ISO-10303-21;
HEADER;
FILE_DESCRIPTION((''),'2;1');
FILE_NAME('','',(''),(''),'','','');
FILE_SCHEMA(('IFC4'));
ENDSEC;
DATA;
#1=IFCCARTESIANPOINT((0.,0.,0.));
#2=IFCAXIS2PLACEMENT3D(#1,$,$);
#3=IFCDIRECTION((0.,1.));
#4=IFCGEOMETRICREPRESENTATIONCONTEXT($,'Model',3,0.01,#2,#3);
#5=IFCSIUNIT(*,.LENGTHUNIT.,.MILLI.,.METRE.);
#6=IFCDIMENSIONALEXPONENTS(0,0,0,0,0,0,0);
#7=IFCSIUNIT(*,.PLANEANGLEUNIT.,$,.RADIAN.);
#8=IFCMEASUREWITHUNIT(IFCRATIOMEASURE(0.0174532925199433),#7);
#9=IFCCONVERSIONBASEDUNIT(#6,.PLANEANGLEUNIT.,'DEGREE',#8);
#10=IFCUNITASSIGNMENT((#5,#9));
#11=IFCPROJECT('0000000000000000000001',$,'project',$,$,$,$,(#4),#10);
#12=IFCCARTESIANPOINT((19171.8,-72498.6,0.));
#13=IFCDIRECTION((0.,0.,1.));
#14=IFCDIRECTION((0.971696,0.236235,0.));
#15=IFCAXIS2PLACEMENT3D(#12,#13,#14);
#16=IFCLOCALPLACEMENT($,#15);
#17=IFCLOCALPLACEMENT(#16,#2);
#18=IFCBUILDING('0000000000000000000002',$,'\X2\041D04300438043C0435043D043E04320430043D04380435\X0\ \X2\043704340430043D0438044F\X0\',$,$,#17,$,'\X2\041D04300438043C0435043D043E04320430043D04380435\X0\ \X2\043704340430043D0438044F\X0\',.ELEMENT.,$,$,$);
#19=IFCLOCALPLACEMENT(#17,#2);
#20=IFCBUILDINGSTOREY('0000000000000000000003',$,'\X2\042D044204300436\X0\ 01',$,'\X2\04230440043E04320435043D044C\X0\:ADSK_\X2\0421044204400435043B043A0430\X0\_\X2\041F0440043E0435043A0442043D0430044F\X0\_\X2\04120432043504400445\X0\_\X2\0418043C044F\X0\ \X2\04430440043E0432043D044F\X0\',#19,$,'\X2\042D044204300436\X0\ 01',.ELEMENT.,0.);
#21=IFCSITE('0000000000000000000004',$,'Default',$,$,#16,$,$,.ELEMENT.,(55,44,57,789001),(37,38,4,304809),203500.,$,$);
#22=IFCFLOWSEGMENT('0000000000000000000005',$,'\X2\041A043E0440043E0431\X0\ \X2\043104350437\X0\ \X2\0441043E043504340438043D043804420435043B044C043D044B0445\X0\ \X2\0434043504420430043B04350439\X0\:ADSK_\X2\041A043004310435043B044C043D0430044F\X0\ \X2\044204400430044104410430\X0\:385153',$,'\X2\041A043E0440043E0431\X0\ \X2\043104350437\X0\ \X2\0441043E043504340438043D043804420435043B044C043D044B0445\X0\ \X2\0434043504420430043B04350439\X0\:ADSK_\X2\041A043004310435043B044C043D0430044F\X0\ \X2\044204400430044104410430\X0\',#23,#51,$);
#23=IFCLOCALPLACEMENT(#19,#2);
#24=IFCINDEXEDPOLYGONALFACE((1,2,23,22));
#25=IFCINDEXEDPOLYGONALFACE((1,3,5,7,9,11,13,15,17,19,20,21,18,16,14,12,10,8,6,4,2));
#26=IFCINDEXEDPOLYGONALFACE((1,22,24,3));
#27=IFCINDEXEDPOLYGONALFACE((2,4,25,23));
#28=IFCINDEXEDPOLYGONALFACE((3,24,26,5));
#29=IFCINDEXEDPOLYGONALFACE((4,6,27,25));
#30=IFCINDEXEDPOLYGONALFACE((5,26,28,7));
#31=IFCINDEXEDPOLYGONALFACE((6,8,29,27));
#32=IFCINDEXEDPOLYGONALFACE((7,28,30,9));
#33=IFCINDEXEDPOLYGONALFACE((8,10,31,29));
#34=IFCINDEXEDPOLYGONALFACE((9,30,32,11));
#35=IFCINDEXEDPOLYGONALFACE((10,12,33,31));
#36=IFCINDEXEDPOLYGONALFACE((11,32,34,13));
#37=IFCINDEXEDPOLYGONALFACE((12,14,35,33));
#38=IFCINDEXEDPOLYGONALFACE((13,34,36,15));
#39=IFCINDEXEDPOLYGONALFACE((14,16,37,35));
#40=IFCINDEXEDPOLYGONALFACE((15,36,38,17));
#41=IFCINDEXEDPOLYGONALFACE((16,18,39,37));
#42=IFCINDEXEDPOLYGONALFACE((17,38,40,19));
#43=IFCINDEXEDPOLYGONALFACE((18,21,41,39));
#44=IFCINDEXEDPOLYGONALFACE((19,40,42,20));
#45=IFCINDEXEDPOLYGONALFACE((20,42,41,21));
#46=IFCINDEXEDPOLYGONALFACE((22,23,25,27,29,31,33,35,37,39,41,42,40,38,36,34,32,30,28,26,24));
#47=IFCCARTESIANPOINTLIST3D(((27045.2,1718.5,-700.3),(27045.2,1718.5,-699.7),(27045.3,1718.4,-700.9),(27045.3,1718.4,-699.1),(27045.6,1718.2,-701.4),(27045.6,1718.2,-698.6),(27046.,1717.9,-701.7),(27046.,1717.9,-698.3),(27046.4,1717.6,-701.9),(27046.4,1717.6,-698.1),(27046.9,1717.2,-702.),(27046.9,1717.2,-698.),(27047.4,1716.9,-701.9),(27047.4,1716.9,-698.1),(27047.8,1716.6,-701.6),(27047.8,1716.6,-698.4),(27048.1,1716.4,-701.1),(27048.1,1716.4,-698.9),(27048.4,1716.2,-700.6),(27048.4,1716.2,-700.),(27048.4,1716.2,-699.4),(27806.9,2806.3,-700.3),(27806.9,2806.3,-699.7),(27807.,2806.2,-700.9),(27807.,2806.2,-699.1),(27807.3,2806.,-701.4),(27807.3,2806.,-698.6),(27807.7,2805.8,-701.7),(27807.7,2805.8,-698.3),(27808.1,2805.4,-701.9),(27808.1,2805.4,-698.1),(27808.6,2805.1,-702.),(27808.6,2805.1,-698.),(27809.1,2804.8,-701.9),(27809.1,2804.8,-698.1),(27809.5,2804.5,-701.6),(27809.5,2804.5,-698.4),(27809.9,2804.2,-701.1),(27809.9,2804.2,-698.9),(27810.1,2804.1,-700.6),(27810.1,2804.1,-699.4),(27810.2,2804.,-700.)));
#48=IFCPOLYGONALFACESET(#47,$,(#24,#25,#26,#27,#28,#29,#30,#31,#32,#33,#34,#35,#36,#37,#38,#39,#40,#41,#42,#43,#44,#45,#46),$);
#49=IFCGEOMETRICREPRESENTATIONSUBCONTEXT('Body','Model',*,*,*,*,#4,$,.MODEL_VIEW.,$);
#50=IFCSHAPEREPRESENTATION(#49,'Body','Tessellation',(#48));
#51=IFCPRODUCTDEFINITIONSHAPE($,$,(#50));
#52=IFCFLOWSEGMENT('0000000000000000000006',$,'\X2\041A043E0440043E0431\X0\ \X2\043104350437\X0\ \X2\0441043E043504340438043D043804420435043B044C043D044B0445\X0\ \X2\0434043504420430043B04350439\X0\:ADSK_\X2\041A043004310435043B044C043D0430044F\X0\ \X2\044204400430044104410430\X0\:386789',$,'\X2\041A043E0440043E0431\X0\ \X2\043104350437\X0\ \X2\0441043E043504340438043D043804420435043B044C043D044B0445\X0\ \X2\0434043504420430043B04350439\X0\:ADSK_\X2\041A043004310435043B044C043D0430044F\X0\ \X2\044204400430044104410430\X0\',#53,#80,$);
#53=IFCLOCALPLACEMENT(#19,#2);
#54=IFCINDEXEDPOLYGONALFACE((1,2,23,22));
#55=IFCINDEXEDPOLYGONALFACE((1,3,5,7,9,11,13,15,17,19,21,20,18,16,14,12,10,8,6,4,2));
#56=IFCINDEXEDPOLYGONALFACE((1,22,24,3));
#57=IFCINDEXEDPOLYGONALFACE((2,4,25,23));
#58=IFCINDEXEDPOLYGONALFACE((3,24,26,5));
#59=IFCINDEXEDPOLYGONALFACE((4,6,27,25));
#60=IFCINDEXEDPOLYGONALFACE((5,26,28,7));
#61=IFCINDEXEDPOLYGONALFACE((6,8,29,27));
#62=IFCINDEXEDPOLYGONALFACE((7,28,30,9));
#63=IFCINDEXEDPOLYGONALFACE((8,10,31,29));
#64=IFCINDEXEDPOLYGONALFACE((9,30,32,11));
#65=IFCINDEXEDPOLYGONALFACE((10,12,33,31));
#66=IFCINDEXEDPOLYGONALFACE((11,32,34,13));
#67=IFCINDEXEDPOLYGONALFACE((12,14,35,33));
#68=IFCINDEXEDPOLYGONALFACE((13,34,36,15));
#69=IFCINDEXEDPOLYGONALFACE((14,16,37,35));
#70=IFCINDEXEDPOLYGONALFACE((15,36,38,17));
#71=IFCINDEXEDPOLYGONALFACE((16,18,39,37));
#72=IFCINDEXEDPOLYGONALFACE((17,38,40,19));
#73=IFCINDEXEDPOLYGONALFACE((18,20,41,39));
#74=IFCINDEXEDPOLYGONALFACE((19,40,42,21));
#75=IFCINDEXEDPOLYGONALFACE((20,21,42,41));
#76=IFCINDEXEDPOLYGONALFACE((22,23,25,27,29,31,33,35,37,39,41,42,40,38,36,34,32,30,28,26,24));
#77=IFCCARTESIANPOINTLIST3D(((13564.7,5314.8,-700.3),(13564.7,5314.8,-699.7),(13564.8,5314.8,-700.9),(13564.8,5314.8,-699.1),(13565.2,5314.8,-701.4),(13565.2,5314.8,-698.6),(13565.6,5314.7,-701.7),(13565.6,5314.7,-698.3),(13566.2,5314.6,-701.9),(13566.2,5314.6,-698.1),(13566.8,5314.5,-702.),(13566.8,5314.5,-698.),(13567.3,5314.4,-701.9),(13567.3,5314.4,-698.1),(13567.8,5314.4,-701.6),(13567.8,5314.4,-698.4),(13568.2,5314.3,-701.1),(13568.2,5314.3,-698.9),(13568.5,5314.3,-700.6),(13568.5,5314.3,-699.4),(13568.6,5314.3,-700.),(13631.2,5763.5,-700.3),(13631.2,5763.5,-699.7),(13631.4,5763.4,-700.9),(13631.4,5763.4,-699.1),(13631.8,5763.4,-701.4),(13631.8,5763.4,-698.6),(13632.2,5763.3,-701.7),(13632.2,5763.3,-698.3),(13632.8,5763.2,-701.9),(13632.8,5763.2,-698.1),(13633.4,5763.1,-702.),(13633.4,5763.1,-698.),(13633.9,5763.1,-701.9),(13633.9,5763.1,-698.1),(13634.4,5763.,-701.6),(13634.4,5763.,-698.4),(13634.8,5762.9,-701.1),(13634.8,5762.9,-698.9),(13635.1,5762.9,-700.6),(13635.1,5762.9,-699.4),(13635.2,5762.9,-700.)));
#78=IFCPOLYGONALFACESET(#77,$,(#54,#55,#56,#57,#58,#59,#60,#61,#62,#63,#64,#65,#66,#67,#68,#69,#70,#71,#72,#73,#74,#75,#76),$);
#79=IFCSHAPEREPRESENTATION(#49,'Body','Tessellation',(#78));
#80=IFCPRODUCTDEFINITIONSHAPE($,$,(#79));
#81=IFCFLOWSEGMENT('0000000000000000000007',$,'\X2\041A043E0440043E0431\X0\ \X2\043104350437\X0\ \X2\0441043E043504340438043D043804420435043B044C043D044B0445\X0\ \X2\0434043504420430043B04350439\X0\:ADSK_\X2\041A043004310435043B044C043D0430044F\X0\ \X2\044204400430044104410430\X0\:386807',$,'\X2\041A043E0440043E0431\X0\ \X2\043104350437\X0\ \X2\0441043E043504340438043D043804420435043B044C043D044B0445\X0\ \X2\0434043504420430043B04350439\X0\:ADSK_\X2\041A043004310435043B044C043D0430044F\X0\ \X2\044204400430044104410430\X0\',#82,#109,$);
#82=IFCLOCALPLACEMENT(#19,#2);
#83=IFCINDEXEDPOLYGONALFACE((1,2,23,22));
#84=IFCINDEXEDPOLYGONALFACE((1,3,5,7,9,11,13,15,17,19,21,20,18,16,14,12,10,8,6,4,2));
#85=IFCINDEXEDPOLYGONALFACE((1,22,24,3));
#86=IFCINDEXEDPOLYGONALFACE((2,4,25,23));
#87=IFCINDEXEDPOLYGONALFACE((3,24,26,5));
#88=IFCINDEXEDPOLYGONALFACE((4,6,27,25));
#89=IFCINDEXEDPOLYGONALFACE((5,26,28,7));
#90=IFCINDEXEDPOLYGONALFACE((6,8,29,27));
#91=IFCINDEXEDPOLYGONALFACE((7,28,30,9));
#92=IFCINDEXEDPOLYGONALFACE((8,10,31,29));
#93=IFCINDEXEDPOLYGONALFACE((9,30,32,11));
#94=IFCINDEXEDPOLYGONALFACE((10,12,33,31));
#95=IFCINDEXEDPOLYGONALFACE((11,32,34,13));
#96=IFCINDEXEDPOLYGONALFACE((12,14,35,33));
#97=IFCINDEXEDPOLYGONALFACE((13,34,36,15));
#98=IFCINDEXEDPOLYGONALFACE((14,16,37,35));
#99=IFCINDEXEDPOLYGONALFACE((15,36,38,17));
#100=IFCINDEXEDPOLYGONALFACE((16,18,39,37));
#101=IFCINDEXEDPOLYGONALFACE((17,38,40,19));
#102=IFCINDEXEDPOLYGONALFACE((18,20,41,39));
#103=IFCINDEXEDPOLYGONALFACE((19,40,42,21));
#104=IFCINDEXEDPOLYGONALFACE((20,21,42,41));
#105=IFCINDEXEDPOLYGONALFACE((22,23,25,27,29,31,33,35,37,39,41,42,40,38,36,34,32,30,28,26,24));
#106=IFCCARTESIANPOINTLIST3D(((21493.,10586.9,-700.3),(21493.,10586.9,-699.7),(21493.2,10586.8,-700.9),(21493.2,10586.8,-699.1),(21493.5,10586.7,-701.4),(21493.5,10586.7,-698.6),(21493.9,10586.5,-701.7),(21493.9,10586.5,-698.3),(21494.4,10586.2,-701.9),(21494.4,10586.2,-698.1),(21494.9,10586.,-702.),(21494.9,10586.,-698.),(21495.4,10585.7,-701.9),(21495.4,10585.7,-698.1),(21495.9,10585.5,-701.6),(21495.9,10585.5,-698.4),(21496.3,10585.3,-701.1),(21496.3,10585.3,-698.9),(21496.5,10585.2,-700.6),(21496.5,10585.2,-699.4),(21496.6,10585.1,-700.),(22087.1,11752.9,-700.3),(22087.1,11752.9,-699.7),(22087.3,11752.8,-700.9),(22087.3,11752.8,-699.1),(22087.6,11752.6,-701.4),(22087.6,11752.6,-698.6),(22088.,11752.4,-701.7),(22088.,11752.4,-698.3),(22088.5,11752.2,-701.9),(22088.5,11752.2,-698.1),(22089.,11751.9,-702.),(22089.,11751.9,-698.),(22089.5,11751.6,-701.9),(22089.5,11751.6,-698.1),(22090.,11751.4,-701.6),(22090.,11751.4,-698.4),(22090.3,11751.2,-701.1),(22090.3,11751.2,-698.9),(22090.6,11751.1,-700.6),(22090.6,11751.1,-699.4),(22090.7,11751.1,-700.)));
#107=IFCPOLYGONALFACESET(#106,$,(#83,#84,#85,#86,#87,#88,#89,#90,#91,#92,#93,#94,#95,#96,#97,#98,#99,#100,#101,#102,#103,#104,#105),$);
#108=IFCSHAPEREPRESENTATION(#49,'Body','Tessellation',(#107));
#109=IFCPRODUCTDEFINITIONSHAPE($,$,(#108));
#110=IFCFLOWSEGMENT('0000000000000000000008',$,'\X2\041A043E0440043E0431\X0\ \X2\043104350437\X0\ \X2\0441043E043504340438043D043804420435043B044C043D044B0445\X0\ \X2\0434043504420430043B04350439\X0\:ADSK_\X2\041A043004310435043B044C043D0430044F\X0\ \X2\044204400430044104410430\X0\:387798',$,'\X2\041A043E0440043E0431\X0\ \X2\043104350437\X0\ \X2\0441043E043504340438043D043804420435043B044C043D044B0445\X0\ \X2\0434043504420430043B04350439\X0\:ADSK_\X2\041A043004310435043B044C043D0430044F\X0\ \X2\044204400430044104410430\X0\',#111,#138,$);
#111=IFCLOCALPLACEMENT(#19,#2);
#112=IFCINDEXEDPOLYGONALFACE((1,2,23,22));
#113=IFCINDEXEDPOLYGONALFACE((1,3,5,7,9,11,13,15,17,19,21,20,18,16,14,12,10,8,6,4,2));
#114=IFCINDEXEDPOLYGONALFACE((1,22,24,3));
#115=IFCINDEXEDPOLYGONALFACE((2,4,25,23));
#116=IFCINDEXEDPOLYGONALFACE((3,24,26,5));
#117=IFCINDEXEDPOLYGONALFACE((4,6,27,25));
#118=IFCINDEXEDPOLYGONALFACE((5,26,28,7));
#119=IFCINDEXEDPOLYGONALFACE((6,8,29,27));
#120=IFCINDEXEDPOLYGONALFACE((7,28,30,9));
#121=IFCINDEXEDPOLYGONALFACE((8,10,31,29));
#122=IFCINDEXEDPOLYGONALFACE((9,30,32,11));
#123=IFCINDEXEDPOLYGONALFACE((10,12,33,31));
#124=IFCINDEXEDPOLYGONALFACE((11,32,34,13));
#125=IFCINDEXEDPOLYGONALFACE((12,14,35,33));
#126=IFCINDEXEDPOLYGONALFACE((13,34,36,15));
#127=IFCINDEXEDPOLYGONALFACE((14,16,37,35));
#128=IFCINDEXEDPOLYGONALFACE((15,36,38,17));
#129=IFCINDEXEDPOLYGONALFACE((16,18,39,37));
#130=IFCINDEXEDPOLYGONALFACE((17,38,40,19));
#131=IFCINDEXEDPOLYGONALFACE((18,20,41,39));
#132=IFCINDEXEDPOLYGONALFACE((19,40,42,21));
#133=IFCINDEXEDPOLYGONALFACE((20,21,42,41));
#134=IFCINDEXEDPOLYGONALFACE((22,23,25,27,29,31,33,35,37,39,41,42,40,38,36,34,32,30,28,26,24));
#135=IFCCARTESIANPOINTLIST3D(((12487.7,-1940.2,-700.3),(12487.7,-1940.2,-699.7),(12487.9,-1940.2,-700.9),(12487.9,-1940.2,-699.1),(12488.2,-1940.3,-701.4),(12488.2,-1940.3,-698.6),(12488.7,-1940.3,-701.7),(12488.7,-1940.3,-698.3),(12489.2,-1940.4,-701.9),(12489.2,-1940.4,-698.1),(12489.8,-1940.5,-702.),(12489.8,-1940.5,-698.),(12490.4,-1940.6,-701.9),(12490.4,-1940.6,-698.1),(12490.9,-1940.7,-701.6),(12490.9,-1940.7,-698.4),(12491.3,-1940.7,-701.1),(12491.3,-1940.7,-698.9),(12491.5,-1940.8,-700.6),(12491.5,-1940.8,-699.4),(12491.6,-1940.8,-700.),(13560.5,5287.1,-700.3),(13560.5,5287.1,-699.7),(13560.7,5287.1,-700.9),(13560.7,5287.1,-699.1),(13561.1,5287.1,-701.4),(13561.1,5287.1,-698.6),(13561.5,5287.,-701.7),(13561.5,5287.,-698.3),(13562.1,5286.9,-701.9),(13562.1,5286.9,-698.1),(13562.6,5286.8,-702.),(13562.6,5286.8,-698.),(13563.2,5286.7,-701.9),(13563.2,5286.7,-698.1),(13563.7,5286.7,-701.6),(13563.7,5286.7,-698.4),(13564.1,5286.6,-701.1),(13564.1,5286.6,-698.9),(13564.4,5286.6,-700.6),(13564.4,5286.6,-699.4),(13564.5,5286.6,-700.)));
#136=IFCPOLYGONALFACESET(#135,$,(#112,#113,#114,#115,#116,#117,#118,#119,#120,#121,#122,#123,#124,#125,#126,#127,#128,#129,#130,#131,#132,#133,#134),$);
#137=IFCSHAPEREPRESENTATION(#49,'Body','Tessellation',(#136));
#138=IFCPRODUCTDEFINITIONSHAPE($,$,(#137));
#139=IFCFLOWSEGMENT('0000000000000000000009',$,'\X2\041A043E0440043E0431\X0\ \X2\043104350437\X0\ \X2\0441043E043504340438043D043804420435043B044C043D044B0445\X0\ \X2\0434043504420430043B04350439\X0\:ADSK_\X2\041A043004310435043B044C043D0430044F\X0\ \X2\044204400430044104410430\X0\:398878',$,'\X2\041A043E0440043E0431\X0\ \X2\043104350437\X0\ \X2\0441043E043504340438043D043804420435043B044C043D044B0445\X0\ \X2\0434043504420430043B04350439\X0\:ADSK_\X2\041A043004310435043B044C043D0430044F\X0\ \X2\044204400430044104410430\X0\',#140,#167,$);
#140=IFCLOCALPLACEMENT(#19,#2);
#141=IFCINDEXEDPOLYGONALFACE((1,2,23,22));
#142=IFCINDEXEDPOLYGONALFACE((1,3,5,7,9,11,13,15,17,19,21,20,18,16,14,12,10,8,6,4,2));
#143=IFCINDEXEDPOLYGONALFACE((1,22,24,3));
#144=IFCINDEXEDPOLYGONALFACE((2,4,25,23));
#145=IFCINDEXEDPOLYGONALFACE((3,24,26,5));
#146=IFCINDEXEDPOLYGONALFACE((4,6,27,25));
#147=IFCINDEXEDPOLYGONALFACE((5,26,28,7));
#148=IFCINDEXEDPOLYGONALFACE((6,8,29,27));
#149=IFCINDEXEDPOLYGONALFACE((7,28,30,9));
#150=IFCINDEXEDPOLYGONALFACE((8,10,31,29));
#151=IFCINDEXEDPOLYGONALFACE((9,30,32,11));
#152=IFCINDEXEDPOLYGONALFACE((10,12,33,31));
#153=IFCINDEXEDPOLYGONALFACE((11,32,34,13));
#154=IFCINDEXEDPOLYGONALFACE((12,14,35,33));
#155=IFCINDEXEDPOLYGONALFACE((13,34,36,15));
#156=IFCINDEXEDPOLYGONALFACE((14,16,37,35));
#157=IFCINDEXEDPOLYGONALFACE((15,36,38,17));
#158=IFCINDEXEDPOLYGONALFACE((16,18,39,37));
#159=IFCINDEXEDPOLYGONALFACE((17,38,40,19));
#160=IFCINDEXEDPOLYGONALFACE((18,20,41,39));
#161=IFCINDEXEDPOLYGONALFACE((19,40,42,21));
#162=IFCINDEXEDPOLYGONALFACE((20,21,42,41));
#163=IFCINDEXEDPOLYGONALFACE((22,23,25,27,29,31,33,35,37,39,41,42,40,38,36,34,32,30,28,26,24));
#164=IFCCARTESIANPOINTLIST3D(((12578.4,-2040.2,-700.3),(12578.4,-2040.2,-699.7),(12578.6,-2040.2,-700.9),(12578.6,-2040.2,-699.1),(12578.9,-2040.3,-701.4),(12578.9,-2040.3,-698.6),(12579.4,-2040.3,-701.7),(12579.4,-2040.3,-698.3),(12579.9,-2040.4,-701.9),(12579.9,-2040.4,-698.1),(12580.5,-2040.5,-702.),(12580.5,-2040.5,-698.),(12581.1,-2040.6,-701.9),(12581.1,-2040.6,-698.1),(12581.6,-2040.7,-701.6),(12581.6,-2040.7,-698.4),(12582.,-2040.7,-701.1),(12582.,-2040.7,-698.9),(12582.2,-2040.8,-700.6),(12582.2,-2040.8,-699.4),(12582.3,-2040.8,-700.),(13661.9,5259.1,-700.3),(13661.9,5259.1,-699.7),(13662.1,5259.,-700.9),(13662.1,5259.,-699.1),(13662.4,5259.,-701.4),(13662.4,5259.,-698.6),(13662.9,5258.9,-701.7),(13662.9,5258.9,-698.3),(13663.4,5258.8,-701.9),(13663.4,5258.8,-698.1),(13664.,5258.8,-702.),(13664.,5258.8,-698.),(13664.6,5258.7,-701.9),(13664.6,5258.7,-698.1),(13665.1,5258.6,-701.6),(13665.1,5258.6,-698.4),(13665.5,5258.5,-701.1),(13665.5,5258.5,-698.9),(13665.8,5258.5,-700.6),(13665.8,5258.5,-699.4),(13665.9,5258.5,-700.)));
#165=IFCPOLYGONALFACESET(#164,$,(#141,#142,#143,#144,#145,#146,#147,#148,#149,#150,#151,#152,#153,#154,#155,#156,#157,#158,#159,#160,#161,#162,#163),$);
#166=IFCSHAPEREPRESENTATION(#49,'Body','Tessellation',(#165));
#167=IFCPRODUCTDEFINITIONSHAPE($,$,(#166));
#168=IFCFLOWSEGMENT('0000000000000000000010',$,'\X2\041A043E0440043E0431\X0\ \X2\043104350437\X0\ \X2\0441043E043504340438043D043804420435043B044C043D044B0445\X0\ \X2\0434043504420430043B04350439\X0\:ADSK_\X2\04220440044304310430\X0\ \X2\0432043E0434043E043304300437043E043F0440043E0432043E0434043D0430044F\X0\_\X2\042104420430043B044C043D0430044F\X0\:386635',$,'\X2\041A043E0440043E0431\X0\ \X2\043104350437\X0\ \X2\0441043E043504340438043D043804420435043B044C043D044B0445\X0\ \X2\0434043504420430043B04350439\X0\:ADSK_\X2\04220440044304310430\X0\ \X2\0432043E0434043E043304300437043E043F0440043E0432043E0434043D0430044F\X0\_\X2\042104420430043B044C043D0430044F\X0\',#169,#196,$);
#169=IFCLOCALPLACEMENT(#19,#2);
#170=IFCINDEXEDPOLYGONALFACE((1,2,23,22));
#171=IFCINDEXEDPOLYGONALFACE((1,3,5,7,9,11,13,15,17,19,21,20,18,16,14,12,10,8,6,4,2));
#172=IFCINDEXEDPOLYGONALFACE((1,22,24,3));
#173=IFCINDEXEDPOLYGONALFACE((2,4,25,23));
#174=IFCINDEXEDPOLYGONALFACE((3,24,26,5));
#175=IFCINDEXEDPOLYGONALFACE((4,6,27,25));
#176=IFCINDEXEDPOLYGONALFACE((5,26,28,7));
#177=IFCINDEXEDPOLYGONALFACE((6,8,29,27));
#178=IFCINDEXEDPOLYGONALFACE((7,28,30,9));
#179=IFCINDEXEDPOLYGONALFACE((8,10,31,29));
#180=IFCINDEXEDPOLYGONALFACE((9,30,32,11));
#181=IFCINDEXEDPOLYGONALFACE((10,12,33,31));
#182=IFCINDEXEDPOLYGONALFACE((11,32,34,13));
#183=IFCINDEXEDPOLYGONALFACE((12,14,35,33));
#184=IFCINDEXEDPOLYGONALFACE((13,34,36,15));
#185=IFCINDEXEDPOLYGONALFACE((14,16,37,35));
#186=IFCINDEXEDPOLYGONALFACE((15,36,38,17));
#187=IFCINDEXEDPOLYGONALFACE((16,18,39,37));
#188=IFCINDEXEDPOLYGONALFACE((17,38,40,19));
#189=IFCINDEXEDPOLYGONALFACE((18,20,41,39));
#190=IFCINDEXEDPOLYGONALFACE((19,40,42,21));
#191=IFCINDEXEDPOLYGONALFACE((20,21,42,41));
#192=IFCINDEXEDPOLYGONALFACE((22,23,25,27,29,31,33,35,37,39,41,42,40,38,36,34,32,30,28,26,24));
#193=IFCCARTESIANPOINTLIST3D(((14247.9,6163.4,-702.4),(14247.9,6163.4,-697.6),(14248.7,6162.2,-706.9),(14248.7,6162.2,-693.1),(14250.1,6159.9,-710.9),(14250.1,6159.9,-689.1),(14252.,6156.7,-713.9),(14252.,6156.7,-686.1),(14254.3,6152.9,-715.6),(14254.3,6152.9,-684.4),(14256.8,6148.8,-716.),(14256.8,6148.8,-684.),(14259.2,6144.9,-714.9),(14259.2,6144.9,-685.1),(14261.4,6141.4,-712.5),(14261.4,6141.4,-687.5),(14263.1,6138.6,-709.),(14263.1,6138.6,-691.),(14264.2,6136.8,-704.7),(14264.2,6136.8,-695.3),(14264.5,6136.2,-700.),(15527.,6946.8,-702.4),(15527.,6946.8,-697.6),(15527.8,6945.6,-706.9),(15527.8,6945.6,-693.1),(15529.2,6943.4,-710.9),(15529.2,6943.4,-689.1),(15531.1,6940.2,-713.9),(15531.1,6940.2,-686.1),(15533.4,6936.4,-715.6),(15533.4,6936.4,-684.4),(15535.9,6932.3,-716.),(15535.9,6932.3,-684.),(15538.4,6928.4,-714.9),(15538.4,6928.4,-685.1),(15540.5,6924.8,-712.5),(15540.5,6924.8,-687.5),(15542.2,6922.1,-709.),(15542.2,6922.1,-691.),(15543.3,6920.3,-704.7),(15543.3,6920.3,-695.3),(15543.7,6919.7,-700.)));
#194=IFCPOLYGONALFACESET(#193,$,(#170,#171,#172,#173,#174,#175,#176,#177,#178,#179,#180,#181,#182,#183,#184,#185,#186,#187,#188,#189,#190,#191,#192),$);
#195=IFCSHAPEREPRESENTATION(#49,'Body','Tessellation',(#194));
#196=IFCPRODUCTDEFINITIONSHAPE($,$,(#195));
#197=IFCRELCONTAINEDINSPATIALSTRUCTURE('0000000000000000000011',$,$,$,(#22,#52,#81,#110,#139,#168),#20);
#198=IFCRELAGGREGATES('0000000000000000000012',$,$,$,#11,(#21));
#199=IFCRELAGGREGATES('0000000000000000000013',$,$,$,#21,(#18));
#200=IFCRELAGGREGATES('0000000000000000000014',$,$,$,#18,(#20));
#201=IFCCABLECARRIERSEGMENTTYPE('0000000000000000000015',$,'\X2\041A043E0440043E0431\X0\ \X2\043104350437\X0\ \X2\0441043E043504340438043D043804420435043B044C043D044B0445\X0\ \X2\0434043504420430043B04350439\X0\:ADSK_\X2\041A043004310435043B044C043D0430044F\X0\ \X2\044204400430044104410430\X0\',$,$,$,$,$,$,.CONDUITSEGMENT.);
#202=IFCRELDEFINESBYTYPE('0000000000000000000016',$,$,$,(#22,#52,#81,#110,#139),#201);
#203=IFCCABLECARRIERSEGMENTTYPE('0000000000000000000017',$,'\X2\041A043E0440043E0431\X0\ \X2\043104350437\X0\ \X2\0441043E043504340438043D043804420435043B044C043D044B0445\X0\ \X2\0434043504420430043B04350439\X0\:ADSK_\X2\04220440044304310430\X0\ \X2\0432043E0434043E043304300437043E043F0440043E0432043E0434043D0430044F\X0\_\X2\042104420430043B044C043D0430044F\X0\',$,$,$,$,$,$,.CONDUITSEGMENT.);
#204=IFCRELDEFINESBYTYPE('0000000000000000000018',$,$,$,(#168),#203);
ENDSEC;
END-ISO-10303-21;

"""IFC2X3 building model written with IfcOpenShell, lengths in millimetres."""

from ifc_helpers import new_model, entity, si_unit, converted_unit, direction, frame, origin, origin_2d_with_axis, place, context, subcontext, project, spatial, circle, extrude, type_object, element, save


model = new_model("IFC2X3")

# Units and contexts
model_context = context("Model", 3, precision=0.01, world=origin(), true_north=direction((0.0, 1.0)))
body_context = subcontext(model_context, "Body", "Model", "MODEL_VIEW")
ifc_project = project(units=[si_unit("LENGTHUNIT", "METRE", prefix="MILLI"), converted_unit("PLANEANGLEUNIT", "DEGREE", entity("IfcRatioMeasure", 0.0174532925199433), si_unit("PLANEANGLEUNIT", "RADIAN"), dimensions=[0, 0, 0, 0, 0, 0, 0])], contexts=[model_context])

# Site, building, storey
site_placement = place(None, frame((19171.8, -72498.6, 0.0), z_axis=(0.0, 0.0, 1.0), x_axis=(0.971696, 0.236235, 0.0)))
site = spatial("IfcSite", under=ifc_project, at=site_placement, Name="Default", CompositionType="ELEMENT", RefLatitude=(55, 44, 57, 789001), RefLongitude=(37, 38, 4, 304809), RefElevation=203500.0)
building_placement = place(site_placement, origin())
building = spatial("IfcBuilding", under=site, at=building_placement, Name="Наименование здания", LongName="Наименование здания", CompositionType="ELEMENT")
storey_placement = place(building_placement, origin())
storey = spatial("IfcBuildingStorey", under=building, at=storey_placement, Name="Этаж 01", ObjectType="Уровень:ADSK_Стрелка_Проектная_Вверх_Имя уровня", LongName="Этаж 01", CompositionType="ELEMENT", Elevation=0.0)

# Flow segments
cable_carrier_segment_type_1 = type_object("IfcCableCarrierSegmentType", Name="Короб без соединительных деталей:ADSK_Кабельная трасса", PredefinedType="CONDUITSEGMENT")
flow_segment_1_placement = place(storey_placement, frame((27043.6, 1714.6, -703.6)))
element("IfcFlowSegment", 1, at=flow_segment_1_placement, inside=storey, type_object=cable_carrier_segment_type_1, Name="Короб без соединительных деталей:ADSK_Кабельная трасса:385153", ObjectType="Короб без соединительных деталей:ADSK_Кабельная трасса", context=body_context, shape_type="SweptSolid", body=[
    extrude(circle(Radius=2.0, at=origin_2d_with_axis()), frame((3.2, 2.7, 3.6), z_axis=(0.573576, 0.819152, 0.0), x_axis=(0.819152, -0.573576, 0.0)), (0.0, 0.0, 1.0), 1328.0),
])
flow_segment_2_placement = place(storey_placement, frame((13563.0, 5312.7, -703.6)))
element("IfcFlowSegment", 2, at=flow_segment_2_placement, inside=storey, type_object=cable_carrier_segment_type_1, Name="Короб без соединительных деталей:ADSK_Кабельная трасса:386789", ObjectType="Короб без соединительных деталей:ADSK_Кабельная трасса", context=body_context, shape_type="SweptSolid", body=[
    extrude(circle(Radius=2.0, at=origin_2d_with_axis()), frame((3.6, 1.9, 3.6), z_axis=(0.146835, 0.989161, 0.0), x_axis=(0.989161, -0.146835, 0.0)), (0.0, 0.0, 1.0), 453.5),
])
flow_segment_3_placement = place(storey_placement, frame((21491.4, 10583.5, -703.6)))
element("IfcFlowSegment", 3, at=flow_segment_3_placement, inside=storey, type_object=cable_carrier_segment_type_1, Name="Короб без соединительных деталей:ADSK_Кабельная трасса:386807", ObjectType="Короб без соединительных деталей:ADSK_Кабельная трасса", context=body_context, shape_type="SweptSolid", body=[
    extrude(circle(Radius=2.0, at=origin_2d_with_axis()), frame((3.4, 2.5, 3.6), z_axis=(0.45399, 0.891007, 0.0), x_axis=(0.891007, -0.45399, 0.0)), (0.0, 0.0, 1.0), 1308.6),
])
flow_segment_4_placement = place(storey_placement, frame((12486.1, -1942.4, -703.6)))
element("IfcFlowSegment", 4, at=flow_segment_4_placement, inside=storey, type_object=cable_carrier_segment_type_1, Name="Короб без соединительных деталей:ADSK_Кабельная трасса:387798", ObjectType="Короб без соединительных деталей:ADSK_Кабельная трасса", context=body_context, shape_type="SweptSolid", body=[
    extrude(circle(Radius=2.0, at=origin_2d_with_axis()), frame((3.6, 1.9, 3.6), z_axis=(0.146835, 0.989161, 0.0), x_axis=(0.989161, -0.146835, 0.0)), (0.0, 0.0, 1.0), 7306.5),
])
flow_segment_5_placement = place(storey_placement, frame((12576.8, -2042.4, -703.6)))
element("IfcFlowSegment", 5, at=flow_segment_5_placement, inside=storey, type_object=cable_carrier_segment_type_1, Name="Короб без соединительных деталей:ADSK_Кабельная трасса:398878", ObjectType="Короб без соединительных деталей:ADSK_Кабельная трасса", context=body_context, shape_type="SweptSolid", body=[
    extrude(circle(Radius=2.0, at=origin_2d_with_axis()), frame((3.6, 1.9, 3.6), z_axis=(0.146835, 0.989161, 0.0), x_axis=(0.989161, -0.146835, 0.0)), (0.0, 0.0, 1.0), 7379.2),
])
cable_carrier_segment_type_2 = type_object("IfcCableCarrierSegmentType", Name="Короб без соединительных деталей:ADSK_Труба водогазопроводная_Стальная", PredefinedType="CONDUITSEGMENT")
flow_segment_6_placement = place(storey_placement, frame((14246.2, 6134.6, -717.6)))
element("IfcFlowSegment", 6, at=flow_segment_6_placement, inside=storey, type_object=cable_carrier_segment_type_2, Name="Короб без соединительных деталей:ADSK_Труба водогазопроводная_Стальная:386635", ObjectType="Короб без соединительных деталей:ADSK_Труба водогазопроводная_Стальная", context=body_context, shape_type="SweptSolid", body=[
    extrude(circle(Radius=16.0, at=origin_2d_with_axis()), frame((9.9, 15.2, 17.6), z_axis=(0.852745, 0.522328, 0.0), x_axis=(0.522328, -0.852745, 0.0)), (0.0, 0.0, 1.0), 1500.0),
])

save(model, "model.ifc")
